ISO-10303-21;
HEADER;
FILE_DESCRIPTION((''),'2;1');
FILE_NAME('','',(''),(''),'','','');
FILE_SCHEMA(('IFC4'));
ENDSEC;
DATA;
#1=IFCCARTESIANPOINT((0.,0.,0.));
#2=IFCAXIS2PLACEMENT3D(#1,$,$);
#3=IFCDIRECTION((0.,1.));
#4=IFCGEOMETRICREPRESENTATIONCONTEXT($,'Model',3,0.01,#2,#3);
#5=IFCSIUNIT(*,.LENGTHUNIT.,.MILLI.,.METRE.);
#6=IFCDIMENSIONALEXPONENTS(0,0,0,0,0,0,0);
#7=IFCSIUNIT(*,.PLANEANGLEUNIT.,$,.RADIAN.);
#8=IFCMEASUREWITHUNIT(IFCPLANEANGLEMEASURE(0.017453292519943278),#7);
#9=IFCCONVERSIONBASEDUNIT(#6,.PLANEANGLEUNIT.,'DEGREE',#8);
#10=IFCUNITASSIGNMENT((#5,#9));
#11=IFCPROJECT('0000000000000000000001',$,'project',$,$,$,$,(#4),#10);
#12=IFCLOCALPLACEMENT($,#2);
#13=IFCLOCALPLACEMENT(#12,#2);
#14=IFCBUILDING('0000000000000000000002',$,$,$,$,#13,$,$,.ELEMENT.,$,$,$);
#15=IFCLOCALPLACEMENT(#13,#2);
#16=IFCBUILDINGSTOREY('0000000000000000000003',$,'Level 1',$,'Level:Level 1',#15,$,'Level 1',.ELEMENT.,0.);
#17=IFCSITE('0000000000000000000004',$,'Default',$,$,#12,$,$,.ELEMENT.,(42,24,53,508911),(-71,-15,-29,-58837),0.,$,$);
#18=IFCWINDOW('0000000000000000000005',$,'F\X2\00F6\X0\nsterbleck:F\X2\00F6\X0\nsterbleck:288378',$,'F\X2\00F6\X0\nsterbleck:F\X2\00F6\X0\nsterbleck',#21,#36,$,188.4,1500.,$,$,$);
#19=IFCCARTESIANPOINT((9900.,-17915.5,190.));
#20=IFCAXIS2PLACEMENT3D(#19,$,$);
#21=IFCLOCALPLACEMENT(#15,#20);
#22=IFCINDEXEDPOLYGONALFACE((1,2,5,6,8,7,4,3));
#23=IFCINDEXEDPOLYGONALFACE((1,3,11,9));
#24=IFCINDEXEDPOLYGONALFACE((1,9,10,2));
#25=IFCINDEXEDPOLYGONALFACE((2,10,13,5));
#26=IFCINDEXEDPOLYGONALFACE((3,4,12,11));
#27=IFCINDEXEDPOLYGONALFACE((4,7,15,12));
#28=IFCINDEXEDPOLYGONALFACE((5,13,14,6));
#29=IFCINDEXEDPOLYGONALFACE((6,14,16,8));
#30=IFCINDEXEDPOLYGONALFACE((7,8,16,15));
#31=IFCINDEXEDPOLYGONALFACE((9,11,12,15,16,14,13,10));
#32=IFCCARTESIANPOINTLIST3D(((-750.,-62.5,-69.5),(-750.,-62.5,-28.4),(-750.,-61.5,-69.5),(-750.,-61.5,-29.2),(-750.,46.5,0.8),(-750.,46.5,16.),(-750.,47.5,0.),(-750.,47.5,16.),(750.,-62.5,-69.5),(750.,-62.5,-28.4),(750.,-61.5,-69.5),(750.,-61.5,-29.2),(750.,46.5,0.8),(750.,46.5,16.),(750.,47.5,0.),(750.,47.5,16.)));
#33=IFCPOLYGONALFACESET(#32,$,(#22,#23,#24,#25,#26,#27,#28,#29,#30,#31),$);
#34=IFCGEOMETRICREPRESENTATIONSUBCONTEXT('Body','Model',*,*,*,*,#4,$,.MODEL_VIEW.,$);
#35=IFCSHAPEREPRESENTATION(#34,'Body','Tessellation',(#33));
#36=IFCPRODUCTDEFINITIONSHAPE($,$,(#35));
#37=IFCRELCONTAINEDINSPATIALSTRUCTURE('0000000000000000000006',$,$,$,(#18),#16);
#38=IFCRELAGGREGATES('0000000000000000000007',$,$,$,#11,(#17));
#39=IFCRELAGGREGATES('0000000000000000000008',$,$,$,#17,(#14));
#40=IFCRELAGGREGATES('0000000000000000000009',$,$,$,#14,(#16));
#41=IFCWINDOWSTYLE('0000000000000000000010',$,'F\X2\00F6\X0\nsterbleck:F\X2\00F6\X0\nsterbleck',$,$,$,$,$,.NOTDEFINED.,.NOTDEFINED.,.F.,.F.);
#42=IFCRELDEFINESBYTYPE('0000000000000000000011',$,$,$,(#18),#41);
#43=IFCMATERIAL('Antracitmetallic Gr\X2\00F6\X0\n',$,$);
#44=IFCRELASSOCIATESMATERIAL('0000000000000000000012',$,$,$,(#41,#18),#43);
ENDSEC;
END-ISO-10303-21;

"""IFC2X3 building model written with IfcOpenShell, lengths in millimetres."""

from ifc_helpers import new_model, entity, si_unit, converted_unit, direction, frame, origin, place, context, subcontext, project, spatial, polyline, outline, extrude, source, transform, mapped, material, type_object, type_shapes, element, save


model = new_model("IFC2X3")

# Units and contexts
model_context = context("Model", 3, precision=0.01, world=origin(), true_north=direction((0.0, 1.0)))
body_context = subcontext(model_context, "Body", "Model", "MODEL_VIEW")
ifc_project = project(units=[si_unit("LENGTHUNIT", "METRE", prefix="MILLI"), converted_unit("PLANEANGLEUNIT", "DEGREE", entity("IfcPlaneAngleMeasure", 0.017453292519943278), si_unit("PLANEANGLEUNIT", "RADIAN"), dimensions=[0, 0, 0, 0, 0, 0, 0])], contexts=[model_context])

# Site, building, storey
site_placement = place(None, origin())
site = spatial("IfcSite", under=ifc_project, at=site_placement, Name="Default", CompositionType="ELEMENT", RefLatitude=(42, 24, 53, 508911), RefLongitude=(-71, -15, -29, -58837), RefElevation=0.0)
building_placement = place(site_placement, origin())
building = spatial("IfcBuilding", under=site, at=building_placement, CompositionType="ELEMENT")
storey_placement = place(building_placement, origin())
storey = spatial("IfcBuildingStorey", under=building, at=storey_placement, Name="Level 1", ObjectType="Level:Level 1", LongName="Level 1", CompositionType="ELEMENT", Elevation=0.0)

# Window
ifc_material_1 = material(Name="Antracitmetallic Grön")
window_style = type_object("IfcWindowStyle", Name="Fönsterbleck:Fönsterbleck", ConstructionType="NOTDEFINED", OperationType="NOTDEFINED", ParameterTakesPrecedence=False, Sizeable=False, material=ifc_material_1)
shared_shape_1 = source(origin(), body_context, "Body", "SweptSolid", [
    extrude(outline(polyline([(-55.0, -36.5), (-54.0, -36.5), (-54.0, -21.2), (55.0, 8.0), (55.0, 49.0), (54.0, 49.0), (54.0, 8.7), (-55.0, -20.5), (-55.0, -36.5)])), frame((-750.0, -7.5, -20.5), z_axis=(1.0, 0.0, 0.0), x_axis=(0.0, -1.0, 0.0)), (0.0, 0.0, 1.0), 1500.0),
])
type_shapes(window_style, [shared_shape_1])
window_placement = place(storey_placement, frame((9900.0, -17915.5, 190.0)))
element("IfcWindow", 1, at=window_placement, inside=storey, type_object=window_style, material=ifc_material_1, Name="Fönsterbleck:Fönsterbleck:288378", ObjectType="Fönsterbleck:Fönsterbleck", OverallHeight=188.4, OverallWidth=1500.0, context=body_context, shape_type="MappedRepresentation", body=[
    mapped(shared_shape_1, transform((0.0, 0.0, 0.0), scale=1.0)),
])

save(model, "model.ifc")
